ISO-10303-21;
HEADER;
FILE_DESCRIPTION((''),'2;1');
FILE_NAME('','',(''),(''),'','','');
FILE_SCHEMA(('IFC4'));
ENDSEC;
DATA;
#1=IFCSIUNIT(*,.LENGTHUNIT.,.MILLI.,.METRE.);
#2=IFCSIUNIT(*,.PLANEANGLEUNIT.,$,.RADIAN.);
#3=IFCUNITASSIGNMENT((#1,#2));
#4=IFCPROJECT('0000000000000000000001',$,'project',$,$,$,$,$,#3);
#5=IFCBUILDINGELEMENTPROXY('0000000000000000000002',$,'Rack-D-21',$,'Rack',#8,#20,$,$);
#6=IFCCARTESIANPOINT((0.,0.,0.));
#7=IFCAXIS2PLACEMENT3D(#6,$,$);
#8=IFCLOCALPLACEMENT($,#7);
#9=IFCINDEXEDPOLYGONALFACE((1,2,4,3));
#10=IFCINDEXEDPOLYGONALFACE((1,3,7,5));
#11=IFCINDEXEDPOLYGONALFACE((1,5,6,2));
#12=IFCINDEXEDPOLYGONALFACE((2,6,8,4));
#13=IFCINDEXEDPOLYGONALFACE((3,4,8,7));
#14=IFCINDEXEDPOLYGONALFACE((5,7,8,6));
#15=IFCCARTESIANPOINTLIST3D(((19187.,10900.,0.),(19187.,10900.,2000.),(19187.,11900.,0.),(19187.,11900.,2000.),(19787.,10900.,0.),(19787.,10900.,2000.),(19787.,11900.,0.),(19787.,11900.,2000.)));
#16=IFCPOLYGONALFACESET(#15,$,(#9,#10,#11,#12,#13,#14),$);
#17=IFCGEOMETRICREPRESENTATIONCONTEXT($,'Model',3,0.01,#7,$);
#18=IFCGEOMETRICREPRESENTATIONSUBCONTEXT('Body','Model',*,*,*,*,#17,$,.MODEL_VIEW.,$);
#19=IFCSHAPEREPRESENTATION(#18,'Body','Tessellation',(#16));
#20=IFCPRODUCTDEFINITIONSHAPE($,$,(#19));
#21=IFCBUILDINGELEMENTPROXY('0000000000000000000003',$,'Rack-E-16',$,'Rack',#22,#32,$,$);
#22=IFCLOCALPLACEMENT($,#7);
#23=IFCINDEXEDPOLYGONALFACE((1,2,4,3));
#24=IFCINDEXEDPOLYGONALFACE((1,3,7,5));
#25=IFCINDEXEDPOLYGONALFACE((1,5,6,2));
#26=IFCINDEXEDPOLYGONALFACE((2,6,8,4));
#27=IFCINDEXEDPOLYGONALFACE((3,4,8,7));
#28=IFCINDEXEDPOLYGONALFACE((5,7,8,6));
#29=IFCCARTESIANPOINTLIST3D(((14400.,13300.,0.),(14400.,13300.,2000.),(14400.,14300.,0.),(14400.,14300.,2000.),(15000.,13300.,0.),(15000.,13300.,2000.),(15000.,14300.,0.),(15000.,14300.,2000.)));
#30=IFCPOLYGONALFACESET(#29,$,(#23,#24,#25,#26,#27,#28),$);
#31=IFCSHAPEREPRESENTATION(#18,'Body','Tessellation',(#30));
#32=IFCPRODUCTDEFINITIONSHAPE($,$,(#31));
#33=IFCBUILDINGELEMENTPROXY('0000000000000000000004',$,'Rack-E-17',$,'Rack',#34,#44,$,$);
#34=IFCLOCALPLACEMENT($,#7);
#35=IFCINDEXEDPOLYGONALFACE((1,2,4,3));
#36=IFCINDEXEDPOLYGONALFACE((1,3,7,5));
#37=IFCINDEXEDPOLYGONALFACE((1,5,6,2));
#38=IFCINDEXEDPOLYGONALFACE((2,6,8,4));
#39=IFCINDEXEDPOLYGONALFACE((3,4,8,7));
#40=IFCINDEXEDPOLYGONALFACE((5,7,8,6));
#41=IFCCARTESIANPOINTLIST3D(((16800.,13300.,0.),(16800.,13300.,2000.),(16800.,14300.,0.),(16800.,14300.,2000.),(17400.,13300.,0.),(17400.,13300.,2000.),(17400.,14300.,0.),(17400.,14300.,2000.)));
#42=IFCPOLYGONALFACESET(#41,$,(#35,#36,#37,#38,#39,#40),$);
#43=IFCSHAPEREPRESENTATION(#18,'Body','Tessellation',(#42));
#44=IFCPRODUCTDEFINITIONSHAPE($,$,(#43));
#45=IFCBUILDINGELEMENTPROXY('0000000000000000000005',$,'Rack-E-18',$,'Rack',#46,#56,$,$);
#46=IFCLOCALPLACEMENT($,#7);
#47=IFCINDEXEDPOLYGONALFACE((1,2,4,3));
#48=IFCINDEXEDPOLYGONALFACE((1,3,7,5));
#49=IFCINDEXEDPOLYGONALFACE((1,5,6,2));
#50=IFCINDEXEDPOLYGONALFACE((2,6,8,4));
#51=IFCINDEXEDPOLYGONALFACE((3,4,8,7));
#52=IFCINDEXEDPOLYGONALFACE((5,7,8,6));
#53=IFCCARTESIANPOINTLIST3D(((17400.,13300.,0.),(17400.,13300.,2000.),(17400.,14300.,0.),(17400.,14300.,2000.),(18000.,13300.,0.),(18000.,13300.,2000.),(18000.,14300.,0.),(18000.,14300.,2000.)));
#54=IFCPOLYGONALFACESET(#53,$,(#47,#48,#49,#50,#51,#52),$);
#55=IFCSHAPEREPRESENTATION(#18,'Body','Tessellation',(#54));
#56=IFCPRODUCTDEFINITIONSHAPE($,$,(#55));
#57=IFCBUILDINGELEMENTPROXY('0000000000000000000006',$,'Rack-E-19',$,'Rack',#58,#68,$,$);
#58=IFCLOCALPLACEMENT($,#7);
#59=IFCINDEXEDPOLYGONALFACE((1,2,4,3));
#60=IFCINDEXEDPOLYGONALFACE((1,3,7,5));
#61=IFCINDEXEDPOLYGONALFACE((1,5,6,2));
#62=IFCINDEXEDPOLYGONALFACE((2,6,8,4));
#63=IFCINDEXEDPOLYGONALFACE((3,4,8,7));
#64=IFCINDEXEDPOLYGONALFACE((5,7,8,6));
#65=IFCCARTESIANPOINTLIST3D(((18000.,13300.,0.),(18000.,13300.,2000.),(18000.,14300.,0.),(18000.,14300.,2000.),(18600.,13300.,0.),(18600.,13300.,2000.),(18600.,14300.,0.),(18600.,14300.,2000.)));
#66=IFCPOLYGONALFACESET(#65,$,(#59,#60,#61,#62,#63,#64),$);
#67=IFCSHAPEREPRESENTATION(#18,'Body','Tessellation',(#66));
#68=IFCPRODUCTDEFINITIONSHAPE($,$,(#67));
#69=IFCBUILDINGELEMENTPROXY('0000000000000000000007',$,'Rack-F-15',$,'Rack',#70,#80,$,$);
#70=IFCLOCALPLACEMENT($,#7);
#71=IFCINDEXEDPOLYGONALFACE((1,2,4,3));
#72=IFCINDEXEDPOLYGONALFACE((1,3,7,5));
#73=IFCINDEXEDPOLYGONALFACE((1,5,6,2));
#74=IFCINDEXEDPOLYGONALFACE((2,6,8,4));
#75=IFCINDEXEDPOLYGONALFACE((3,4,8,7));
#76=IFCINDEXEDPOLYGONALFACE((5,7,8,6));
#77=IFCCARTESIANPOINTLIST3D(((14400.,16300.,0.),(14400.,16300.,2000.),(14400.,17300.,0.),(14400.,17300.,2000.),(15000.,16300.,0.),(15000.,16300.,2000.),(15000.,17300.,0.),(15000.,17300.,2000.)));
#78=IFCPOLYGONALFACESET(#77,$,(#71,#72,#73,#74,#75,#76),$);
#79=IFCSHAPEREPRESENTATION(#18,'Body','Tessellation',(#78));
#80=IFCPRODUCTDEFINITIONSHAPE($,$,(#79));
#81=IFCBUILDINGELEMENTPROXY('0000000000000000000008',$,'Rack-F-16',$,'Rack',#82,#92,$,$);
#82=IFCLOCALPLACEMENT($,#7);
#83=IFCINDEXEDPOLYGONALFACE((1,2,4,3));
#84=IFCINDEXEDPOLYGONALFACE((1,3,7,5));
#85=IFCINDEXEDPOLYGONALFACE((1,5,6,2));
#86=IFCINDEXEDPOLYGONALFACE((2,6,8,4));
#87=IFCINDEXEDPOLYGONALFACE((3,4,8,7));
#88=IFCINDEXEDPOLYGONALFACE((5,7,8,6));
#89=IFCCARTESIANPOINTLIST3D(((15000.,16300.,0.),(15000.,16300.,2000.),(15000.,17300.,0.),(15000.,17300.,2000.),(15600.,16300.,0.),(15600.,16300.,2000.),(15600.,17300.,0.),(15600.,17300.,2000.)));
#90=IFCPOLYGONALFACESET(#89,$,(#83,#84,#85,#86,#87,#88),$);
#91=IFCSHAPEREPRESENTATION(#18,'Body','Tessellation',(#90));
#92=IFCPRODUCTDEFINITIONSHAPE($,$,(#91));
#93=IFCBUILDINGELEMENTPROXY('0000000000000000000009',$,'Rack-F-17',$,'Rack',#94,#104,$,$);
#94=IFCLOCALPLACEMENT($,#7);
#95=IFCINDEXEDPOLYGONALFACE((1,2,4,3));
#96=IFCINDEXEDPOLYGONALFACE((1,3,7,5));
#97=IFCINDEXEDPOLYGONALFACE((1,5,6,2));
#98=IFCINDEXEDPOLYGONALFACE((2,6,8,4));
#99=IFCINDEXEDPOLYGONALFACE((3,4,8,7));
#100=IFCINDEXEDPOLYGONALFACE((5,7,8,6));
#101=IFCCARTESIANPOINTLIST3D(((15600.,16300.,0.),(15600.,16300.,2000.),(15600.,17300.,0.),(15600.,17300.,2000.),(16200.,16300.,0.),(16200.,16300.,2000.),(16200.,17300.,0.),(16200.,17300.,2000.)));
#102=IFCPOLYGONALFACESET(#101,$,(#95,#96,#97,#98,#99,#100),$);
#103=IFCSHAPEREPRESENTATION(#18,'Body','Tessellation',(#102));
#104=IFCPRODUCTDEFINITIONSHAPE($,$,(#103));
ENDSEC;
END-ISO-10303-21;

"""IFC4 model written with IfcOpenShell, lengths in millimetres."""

from ifc_helpers import new_model, si_unit, frame, origin, place, context, subcontext, project, rectangle, extrude, element, save


model = new_model("IFC4")

# Units and contexts
model_context = context("Model", 3, precision=0.01, world=origin())
body_context = subcontext(model_context, "Body", "Model", "MODEL_VIEW")
ifc_project = project(units=[si_unit("LENGTHUNIT", "METRE", prefix="MILLI"), si_unit("PLANEANGLEUNIT", "RADIAN")])

# Shared definitions
placement = place(None, origin())

# Building element proxies
for number, where, name in (
    (1, (19487.0, 11400.0, 0.0), "Rack-D-21"),
    (2, (14700.0, 13800.0, 0.0), "Rack-E-16"),
    (3, (17100.0, 13800.0, 0.0), "Rack-E-17"),
    (4, (17700.0, 13800.0, 0.0), "Rack-E-18"),
    (5, (18300.0, 13800.0, 0.0), "Rack-E-19"),
    (6, (14700.0, 16800.0, 0.0), "Rack-F-15"),
    (7, (15300.0, 16800.0, 0.0), "Rack-F-16"),
    (8, (15900.0, 16800.0, 0.0), "Rack-F-17"),
):
    element("IfcBuildingElementProxy", number, at=place(placement, frame(where)), Name=name, ObjectType="Rack", context=body_context, shape_type="SweptSolid", body=[
        extrude(rectangle(XDim=600.0, YDim=1000.0), origin(), (0.0, 0.0, 1.0), 2000.0),
    ])

save(model, "model.ifc")
